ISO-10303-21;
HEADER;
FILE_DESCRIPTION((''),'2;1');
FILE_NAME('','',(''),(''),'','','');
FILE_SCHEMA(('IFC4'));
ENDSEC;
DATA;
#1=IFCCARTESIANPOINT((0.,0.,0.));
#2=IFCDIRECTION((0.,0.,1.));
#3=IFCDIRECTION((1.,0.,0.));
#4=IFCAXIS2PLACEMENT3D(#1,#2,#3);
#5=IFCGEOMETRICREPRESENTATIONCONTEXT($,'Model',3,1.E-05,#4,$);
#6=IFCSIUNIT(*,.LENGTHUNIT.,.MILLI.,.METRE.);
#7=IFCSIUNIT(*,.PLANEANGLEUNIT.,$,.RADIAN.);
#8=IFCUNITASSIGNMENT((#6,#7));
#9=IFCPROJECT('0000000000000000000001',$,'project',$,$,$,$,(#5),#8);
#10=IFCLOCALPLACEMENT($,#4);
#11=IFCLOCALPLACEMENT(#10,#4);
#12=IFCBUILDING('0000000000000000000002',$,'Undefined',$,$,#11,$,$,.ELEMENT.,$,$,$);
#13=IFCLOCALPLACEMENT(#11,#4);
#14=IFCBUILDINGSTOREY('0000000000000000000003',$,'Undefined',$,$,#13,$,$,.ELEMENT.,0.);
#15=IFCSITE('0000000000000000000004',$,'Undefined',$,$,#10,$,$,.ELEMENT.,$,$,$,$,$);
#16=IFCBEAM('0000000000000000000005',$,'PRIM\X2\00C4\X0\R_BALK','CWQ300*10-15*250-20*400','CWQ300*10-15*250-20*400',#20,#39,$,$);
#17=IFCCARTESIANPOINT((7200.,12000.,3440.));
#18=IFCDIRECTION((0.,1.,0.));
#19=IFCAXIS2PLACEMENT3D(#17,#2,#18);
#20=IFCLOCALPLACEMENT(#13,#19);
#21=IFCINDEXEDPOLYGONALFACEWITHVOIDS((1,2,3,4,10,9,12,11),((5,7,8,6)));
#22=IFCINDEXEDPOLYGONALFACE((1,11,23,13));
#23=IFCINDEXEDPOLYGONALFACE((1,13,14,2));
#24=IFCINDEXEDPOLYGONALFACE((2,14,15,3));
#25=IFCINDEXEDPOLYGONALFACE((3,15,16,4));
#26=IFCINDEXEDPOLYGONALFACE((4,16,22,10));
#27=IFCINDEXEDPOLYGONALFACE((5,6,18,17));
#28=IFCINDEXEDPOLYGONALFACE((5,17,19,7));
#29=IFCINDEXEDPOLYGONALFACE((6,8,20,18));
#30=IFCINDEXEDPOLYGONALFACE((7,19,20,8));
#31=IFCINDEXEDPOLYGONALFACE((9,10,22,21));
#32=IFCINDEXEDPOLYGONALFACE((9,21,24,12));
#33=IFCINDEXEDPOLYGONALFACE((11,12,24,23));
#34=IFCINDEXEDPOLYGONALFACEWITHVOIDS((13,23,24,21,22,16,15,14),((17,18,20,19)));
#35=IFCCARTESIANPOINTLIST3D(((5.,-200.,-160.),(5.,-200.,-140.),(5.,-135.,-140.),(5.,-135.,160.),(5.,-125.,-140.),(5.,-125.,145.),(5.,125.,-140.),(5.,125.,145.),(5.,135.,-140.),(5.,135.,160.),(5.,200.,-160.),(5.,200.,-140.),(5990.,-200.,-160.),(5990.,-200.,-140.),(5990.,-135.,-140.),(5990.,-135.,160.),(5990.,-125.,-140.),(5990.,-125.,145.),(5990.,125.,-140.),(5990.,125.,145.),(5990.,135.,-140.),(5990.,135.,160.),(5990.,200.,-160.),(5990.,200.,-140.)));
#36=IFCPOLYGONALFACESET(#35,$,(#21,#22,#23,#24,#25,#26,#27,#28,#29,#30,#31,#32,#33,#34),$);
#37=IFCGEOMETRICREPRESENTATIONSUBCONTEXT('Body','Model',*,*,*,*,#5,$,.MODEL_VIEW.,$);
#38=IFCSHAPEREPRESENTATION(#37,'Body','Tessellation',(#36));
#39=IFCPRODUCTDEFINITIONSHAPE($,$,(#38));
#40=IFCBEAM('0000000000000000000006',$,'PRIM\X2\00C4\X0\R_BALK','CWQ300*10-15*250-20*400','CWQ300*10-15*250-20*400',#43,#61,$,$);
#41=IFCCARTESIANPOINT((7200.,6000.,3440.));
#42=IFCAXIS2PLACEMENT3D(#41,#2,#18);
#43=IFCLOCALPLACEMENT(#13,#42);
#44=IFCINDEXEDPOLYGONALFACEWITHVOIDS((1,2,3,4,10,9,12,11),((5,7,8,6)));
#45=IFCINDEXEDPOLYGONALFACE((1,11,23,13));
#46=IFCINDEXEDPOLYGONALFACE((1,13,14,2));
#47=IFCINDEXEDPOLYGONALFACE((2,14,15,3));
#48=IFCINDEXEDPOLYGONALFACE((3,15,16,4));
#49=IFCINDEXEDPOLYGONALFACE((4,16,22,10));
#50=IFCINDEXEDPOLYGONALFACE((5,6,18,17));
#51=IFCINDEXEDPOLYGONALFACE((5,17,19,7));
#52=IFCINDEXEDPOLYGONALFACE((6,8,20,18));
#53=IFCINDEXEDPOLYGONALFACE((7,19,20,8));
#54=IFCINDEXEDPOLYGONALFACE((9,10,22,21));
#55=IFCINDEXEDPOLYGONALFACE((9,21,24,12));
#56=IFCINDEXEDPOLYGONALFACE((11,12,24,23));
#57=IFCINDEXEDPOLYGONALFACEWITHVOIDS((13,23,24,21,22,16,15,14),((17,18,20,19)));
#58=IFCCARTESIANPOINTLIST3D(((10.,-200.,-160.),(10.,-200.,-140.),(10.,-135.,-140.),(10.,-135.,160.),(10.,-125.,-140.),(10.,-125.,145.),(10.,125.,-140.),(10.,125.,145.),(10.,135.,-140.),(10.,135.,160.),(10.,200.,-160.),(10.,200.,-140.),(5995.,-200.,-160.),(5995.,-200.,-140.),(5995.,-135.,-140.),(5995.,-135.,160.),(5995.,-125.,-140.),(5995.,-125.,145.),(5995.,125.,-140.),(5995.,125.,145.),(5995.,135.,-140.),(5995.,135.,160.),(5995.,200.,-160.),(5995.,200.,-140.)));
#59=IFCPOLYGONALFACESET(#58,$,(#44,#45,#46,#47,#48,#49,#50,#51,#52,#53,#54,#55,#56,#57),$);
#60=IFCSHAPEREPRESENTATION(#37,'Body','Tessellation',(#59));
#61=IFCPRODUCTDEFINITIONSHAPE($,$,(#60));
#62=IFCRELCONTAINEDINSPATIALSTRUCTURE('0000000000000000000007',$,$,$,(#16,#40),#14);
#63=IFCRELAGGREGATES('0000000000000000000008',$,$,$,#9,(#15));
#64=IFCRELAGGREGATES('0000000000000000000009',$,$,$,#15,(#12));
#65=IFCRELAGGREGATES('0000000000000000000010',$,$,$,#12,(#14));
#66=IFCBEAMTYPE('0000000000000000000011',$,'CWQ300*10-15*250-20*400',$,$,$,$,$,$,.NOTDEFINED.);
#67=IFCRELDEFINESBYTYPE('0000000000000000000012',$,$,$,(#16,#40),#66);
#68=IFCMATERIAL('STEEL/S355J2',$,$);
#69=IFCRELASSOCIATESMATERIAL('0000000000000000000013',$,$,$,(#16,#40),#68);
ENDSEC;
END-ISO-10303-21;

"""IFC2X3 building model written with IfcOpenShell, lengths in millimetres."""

from ifc_helpers import new_model, si_unit, frame, origin_with_axes, place, context, subcontext, project, spatial, polyline, outline, extrude, clip, halfspace, material, type_object, element, save


model = new_model("IFC2X3")

# Units and contexts
model_context = context("Model", 3, precision=1e-05, world=origin_with_axes())
body_context = subcontext(model_context, "Body", "Model", "MODEL_VIEW")
ifc_project = project(units=[si_unit("LENGTHUNIT", "METRE", prefix="MILLI"), si_unit("PLANEANGLEUNIT", "RADIAN")], contexts=[model_context])

# Site, building, storey
site_placement = place(None, origin_with_axes())
site = spatial("IfcSite", under=ifc_project, at=site_placement, Name="Undefined", CompositionType="ELEMENT")
building_placement = place(site_placement, origin_with_axes())
building = spatial("IfcBuilding", under=site, at=building_placement, Name="Undefined", CompositionType="ELEMENT")
storey_placement = place(building_placement, origin_with_axes())
storey = spatial("IfcBuildingStorey", under=building, at=storey_placement, Name="Undefined", CompositionType="ELEMENT", Elevation=0.0)

# Shared definitions
ifc_material_1 = material(Name="STEEL/S355J2")

# Beams
beam_type_1 = type_object("IfcBeamType", Name="CWQ300*10-15*250-20*400", PredefinedType="NOTDEFINED")
beam_1_placement = place(storey_placement, frame((7200.0, 12000.0, 3440.0), z_axis=(0.0, 0.0, 1.0), x_axis=(0.0, 1.0, 0.0)))
element("IfcBeam", 1, at=beam_1_placement, inside=storey, type_object=beam_type_1, material=ifc_material_1, Name="PRIMÄR_BALK", Description="CWQ300*10-15*250-20*400", ObjectType="CWQ300*10-15*250-20*400", context=body_context, shape_type="Clipping", body=[
    clip(clip(extrude(outline(polyline([(135.0, 160.0), (135.0, -140.0), (200.0, -140.0), (200.0, -160.0), (-200.0, -160.0), (-200.0, -140.0), (-135.0, -140.0), (-135.0, 160.0), (135.0, 160.0)]), holes=[polyline([(-125.0, -140.0), (125.0, -140.0), (125.0, 145.0), (-125.0, 145.0), (-125.0, -140.0)])]), frame((5990.0, 0.0, 0.0), z_axis=(-1.0, 0.0, 0.0), x_axis=(0.0, -1.0, 0.0)), (0.0, 0.0, 1.0), 5985.0), halfspace(frame((5990.0, 0.0, -160.0), z_axis=(-1.0, 0.0, 0.0), x_axis=(0.0, -1.0, 0.0)), True)), halfspace(frame((5.0, 0.0, -160.0), z_axis=(1.0, 0.0, 0.0), x_axis=(0.0, 1.0, 0.0)), True)),
])
beam_2_placement = place(storey_placement, frame((7200.0, 6000.0, 3440.0), z_axis=(0.0, 0.0, 1.0), x_axis=(0.0, 1.0, 0.0)))
element("IfcBeam", 2, at=beam_2_placement, inside=storey, type_object=beam_type_1, material=ifc_material_1, Name="PRIMÄR_BALK", Description="CWQ300*10-15*250-20*400", ObjectType="CWQ300*10-15*250-20*400", context=body_context, shape_type="Clipping", body=[
    clip(clip(extrude(outline(polyline([(135.0, 160.0), (135.0, -140.0), (200.0, -140.0), (200.0, -160.0), (-200.0, -160.0), (-200.0, -140.0), (-135.0, -140.0), (-135.0, 160.0), (135.0, 160.0)]), holes=[polyline([(-125.0, -140.0), (125.0, -140.0), (125.0, 145.0), (-125.0, 145.0), (-125.0, -140.0)])]), frame((5995.0, 0.0, 0.0), z_axis=(-1.0, 0.0, 0.0), x_axis=(0.0, -1.0, 0.0)), (0.0, 0.0, 1.0), 5985.0), halfspace(frame((5995.0, 0.0, -160.0), z_axis=(1.0, 0.0, 0.0), x_axis=(0.0, 1.0, 0.0)), False)), halfspace(frame((10.0, 0.0, -160.0), z_axis=(1.0, 0.0, 0.0), x_axis=(0.0, 1.0, 0.0)), True)),
])

save(model, "model.ifc")
